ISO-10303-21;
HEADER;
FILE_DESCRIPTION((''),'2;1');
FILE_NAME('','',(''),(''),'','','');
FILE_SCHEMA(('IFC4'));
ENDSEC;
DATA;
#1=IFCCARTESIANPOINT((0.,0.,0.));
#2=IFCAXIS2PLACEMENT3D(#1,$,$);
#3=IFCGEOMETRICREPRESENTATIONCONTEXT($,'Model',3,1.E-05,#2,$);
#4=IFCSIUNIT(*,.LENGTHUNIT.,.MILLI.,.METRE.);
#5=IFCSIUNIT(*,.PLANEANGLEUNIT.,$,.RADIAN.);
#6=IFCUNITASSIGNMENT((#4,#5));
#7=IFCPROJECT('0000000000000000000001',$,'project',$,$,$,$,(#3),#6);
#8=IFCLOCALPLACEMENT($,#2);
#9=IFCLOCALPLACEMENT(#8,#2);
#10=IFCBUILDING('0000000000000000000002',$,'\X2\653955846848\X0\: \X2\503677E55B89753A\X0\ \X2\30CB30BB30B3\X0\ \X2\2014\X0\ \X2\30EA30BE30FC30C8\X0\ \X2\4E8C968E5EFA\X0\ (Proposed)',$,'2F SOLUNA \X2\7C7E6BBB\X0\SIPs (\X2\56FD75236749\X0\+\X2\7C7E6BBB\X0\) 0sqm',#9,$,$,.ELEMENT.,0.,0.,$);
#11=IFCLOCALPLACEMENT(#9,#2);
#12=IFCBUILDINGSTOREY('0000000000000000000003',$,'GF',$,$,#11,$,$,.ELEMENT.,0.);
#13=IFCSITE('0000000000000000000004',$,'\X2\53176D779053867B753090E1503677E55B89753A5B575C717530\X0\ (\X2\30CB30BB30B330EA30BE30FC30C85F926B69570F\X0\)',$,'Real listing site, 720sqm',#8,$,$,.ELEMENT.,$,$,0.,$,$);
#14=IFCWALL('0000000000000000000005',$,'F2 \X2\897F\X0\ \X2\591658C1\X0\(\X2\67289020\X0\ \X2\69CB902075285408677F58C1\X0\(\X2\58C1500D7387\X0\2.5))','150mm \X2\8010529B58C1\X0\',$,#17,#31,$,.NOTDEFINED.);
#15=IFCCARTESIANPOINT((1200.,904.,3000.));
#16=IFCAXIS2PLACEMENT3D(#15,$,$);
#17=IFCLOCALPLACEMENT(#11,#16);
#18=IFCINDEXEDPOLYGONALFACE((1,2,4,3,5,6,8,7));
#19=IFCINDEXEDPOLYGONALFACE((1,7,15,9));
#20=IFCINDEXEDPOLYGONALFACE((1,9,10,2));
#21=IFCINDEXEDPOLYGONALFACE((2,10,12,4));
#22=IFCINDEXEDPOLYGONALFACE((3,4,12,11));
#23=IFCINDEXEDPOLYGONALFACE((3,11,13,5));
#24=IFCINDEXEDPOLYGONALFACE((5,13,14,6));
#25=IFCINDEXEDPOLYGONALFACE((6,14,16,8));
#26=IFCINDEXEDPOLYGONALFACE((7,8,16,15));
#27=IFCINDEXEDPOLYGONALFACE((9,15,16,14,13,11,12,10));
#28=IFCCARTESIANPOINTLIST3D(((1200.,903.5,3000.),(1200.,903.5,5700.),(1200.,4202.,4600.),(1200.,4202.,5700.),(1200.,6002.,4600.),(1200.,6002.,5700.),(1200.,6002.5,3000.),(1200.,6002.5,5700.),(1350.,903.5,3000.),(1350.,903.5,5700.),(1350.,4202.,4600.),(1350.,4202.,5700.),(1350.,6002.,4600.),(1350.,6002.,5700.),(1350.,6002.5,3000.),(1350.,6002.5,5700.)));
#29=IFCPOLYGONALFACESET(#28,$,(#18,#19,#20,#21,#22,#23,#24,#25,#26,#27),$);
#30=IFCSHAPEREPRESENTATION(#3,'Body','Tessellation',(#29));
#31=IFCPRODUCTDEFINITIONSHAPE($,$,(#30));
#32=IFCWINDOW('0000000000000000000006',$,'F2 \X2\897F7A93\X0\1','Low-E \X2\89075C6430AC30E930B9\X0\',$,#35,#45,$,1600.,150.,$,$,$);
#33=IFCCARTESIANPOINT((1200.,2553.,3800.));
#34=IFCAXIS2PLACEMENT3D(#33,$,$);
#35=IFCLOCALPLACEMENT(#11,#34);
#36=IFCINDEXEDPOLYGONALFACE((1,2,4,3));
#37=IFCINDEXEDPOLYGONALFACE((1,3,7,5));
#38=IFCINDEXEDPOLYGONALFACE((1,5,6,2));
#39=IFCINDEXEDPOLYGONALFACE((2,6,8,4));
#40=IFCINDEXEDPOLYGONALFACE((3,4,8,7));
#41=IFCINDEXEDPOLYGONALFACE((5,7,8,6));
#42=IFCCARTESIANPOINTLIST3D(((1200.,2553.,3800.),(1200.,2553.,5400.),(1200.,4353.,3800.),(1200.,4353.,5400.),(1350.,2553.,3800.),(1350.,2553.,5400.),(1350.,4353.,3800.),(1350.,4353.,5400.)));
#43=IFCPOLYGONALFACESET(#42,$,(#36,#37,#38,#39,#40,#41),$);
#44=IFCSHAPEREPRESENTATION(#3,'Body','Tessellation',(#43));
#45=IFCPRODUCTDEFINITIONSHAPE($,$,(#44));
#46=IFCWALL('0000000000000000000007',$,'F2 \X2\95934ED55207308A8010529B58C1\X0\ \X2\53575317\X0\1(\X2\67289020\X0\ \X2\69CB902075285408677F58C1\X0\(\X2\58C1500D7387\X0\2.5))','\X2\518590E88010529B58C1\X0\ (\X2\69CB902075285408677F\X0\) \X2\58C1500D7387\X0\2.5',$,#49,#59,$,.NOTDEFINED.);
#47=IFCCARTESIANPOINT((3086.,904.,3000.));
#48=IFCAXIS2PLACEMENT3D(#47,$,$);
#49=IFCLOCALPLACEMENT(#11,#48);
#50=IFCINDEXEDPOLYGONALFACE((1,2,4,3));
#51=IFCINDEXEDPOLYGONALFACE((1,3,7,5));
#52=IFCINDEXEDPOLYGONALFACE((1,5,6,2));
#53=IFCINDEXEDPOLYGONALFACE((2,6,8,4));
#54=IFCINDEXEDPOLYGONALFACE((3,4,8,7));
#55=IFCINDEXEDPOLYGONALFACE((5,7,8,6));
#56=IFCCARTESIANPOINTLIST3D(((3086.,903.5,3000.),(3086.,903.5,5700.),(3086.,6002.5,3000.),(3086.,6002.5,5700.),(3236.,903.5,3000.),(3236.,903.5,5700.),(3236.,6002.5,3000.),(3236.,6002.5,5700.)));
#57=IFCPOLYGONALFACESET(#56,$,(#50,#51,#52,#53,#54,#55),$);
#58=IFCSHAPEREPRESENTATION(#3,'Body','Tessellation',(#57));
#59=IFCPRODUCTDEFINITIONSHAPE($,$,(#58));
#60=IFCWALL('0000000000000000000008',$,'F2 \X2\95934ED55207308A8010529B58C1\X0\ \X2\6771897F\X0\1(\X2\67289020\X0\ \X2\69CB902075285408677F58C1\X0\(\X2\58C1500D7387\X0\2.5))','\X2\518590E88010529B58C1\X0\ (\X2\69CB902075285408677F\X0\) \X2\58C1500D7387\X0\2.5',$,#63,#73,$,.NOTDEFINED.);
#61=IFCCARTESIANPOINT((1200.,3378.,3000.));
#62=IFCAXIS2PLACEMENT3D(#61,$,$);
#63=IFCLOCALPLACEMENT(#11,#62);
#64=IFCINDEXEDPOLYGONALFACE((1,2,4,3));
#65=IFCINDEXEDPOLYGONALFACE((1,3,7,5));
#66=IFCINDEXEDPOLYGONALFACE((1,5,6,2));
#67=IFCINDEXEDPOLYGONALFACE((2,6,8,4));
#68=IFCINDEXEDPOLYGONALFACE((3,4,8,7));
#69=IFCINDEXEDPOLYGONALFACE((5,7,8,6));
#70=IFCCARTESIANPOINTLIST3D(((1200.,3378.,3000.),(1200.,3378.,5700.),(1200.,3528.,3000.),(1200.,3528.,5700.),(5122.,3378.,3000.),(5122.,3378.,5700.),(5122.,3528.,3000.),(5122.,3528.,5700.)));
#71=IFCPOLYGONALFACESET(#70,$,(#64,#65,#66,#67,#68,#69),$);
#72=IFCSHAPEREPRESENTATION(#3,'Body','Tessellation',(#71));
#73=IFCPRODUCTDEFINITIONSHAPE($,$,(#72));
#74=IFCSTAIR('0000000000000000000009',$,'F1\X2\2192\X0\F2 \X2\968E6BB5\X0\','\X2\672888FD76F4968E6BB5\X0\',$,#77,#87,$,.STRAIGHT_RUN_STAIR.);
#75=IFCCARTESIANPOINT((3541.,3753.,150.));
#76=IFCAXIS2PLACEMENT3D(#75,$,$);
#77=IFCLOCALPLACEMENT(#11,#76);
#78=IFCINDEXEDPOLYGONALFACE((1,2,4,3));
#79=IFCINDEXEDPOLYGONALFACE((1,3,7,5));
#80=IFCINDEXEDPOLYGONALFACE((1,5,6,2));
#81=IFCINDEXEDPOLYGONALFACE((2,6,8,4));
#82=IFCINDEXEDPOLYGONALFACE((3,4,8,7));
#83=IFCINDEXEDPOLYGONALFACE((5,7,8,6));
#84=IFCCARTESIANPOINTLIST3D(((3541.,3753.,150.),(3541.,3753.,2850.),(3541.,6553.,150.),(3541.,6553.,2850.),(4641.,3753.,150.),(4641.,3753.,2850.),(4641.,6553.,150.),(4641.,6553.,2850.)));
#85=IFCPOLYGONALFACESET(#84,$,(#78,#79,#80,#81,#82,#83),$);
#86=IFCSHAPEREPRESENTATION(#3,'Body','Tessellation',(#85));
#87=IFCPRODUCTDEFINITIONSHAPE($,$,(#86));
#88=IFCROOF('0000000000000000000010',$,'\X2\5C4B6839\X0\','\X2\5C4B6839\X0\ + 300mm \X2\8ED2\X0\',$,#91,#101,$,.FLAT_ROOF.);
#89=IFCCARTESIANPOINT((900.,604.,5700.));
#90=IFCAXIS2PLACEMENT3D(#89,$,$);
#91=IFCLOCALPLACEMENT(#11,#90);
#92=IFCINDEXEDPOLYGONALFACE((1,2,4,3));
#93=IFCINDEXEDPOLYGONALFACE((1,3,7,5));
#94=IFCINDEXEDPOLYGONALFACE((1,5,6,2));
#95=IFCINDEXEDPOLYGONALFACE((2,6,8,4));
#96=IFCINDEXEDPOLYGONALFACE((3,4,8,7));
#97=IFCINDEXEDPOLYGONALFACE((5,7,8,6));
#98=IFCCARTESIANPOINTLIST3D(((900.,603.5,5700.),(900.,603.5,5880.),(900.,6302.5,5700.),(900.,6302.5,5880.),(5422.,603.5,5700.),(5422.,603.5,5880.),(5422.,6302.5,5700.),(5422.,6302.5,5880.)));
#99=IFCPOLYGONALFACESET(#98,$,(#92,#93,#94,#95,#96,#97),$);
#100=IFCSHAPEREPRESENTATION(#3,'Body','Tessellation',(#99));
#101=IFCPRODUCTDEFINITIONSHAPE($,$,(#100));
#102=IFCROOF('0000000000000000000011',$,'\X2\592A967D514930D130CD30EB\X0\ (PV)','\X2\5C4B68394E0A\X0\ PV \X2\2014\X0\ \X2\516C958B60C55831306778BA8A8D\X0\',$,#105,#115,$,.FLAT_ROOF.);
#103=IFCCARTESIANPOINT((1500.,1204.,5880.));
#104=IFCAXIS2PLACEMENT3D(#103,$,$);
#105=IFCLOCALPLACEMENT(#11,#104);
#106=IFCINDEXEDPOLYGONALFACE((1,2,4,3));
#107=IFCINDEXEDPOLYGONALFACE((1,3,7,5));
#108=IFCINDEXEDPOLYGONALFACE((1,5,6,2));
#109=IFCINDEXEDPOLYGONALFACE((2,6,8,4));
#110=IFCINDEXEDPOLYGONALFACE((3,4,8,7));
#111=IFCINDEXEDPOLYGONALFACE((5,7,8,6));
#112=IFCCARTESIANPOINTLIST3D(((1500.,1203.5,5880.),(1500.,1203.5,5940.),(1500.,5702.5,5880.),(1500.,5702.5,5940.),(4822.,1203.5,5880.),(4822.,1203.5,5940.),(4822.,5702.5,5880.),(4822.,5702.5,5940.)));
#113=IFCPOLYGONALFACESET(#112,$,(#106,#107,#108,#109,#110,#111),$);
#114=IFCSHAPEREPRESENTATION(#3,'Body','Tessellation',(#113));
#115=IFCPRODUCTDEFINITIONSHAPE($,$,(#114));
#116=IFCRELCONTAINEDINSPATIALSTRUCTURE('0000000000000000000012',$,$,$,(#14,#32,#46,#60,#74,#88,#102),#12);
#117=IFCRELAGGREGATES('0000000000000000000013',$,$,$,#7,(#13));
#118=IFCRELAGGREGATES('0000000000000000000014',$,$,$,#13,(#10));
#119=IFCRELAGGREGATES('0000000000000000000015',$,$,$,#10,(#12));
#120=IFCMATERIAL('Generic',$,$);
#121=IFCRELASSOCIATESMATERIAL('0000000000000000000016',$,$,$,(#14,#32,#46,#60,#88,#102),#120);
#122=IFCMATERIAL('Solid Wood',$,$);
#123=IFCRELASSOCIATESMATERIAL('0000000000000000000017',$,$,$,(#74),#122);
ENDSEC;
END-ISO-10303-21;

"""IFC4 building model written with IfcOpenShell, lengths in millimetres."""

from ifc_helpers import new_model, si_unit, frame, frame_2d, origin, place, context, project, spatial, rectangle, extrude, material, element, fill, save


model = new_model("IFC4")

# Units and contexts
model_context = context("Model", 3, precision=1e-05, world=origin())
ifc_project = project(units=[si_unit("LENGTHUNIT", "METRE", prefix="MILLI"), si_unit("PLANEANGLEUNIT", "RADIAN")], contexts=[model_context])

# Site, building, storey
site_placement = place(None, origin())
site = spatial("IfcSite", under=ifc_project, at=site_placement, Name="北海道虻田郡倶知安町字山田 (ニセコリゾート徒歩圏)", ObjectType="Real listing site, 720sqm", CompositionType="ELEMENT", RefElevation=0.0)
building_placement = place(site_placement, origin())
building = spatial("IfcBuilding", under=site, at=building_placement, Name="改善案: 倶知安町 ニセコ — リゾート 二階建 (Proposed)", ObjectType="2F SOLUNA 籾殻SIPs (国産杉+籾殻) 0sqm", CompositionType="ELEMENT", ElevationOfRefHeight=0.0, ElevationOfTerrain=0.0)
storey_placement = place(building_placement, origin())
storey = spatial("IfcBuildingStorey", under=building, at=storey_placement, Name="GF", CompositionType="ELEMENT", Elevation=0.0)

# Shared definitions
ifc_material_1 = material(Name="Generic")

# Shared definitions
ifc_material_2 = material(Name="Solid Wood")

# Wall, opening, window
wall_1_placement = place(storey_placement, frame((1200.0, 904.0, 3000.0)))
wall_1 = element("IfcWall", 1, at=wall_1_placement, inside=storey, material=ifc_material_1, Name="F2 西 外壁(木造 構造用合板壁(壁倍率2.5))", Description="150mm 耐力壁", PredefinedType="NOTDEFINED", context=model_context, shape_type="SweptSolid", body=[
    extrude(rectangle(XDim=150.0, YDim=5099.0, at=frame_2d((75.0, 2549.0))), frame((1200.0, 904.0, 3000.0)), (0.0, 0.0, 1.0), 2700.0),
])
opening_1_placement = place(storey_placement, frame((1200.0, 2553.0, 3800.0)))
opening_1 = element("IfcOpeningElement", 2, at=opening_1_placement, cuts=wall_1, PredefinedType="NOTDEFINED", context=model_context, shape_type="SweptSolid", body=[
    extrude(rectangle(XDim=150.0, YDim=1800.0, at=frame_2d((75.0, 900.0))), frame((1200.0, 2553.0, 3800.0)), (0.0, 0.0, 1.0), 1600.0),
])
window_1_placement = place(storey_placement, frame((1200.0, 2553.0, 3800.0)))
window_1 = element("IfcWindow", 3, at=window_1_placement, inside=storey, material=ifc_material_1, Name="F2 西窓1", Description="Low-E 複層ガラス", OverallHeight=1600.0, OverallWidth=150.0, context=model_context, shape_type="SweptSolid", body=[
    extrude(rectangle(XDim=150.0, YDim=1800.0, at=frame_2d((75.0, 900.0))), frame((1200.0, 2553.0, 3800.0)), (0.0, 0.0, 1.0), 1600.0),
])
fill(opening_1, window_1)

# Walls
wall_2_placement = place(storey_placement, frame((3086.0, 904.0, 3000.0)))
element("IfcWall", 4, at=wall_2_placement, inside=storey, material=ifc_material_1, Name="F2 間仕切り耐力壁 南北1(木造 構造用合板壁(壁倍率2.5))", Description="内部耐力壁 (構造用合板) 壁倍率2.5", PredefinedType="NOTDEFINED", context=model_context, shape_type="SweptSolid", body=[
    extrude(rectangle(XDim=150.0, YDim=5099.0, at=frame_2d((75.0, 2549.0))), frame((3086.0, 904.0, 3000.0)), (0.0, 0.0, 1.0), 2700.0),
])
wall_3_placement = place(storey_placement, frame((1200.0, 3378.0, 3000.0)))
element("IfcWall", 5, at=wall_3_placement, inside=storey, material=ifc_material_1, Name="F2 間仕切り耐力壁 東西1(木造 構造用合板壁(壁倍率2.5))", Description="内部耐力壁 (構造用合板) 壁倍率2.5", PredefinedType="NOTDEFINED", context=model_context, shape_type="SweptSolid", body=[
    extrude(rectangle(XDim=3922.0, YDim=150.0, at=frame_2d((1961.0, 75.0))), frame((1200.0, 3378.0, 3000.0)), (0.0, 0.0, 1.0), 2700.0),
])

# Stair
stair_placement = place(storey_placement, frame((3541.0, 3753.0, 150.0)))
element("IfcStair", 6, at=stair_placement, inside=storey, material=ifc_material_2, Name="F1→F2 階段", Description="木製直階段", PredefinedType="STRAIGHT_RUN_STAIR", context=model_context, shape_type="SweptSolid", body=[
    extrude(rectangle(XDim=1100.0, YDim=2800.0, at=frame_2d((550.0, 1400.0))), frame((3541.0, 3753.0, 150.0)), (0.0, 0.0, 1.0), 2700.0),
])

# Roofs
roof_1_placement = place(storey_placement, frame((900.0, 604.0, 5700.0)))
element("IfcRoof", 7, at=roof_1_placement, inside=storey, material=ifc_material_1, Name="屋根", Description="屋根 + 300mm 軒", PredefinedType="FLAT_ROOF", context=model_context, shape_type="SweptSolid", body=[
    extrude(rectangle(XDim=4522.0, YDim=5699.0, at=frame_2d((2261.0, 2849.0))), frame((900.0, 604.0, 5700.0)), (0.0, 0.0, 1.0), 180.0),
])
roof_2_placement = place(storey_placement, frame((1500.0, 1204.0, 5880.0)))
element("IfcRoof", 8, at=roof_2_placement, inside=storey, material=ifc_material_1, Name="太陽光パネル (PV)", Description="屋根上 PV — 公開情報で確認", PredefinedType="FLAT_ROOF", context=model_context, shape_type="SweptSolid", body=[
    extrude(rectangle(XDim=3322.0, YDim=4499.0, at=frame_2d((1661.0, 2249.0))), frame((1500.0, 1204.0, 5880.0)), (0.0, 0.0, 1.0), 60.0),
])

save(model, "model.ifc")
